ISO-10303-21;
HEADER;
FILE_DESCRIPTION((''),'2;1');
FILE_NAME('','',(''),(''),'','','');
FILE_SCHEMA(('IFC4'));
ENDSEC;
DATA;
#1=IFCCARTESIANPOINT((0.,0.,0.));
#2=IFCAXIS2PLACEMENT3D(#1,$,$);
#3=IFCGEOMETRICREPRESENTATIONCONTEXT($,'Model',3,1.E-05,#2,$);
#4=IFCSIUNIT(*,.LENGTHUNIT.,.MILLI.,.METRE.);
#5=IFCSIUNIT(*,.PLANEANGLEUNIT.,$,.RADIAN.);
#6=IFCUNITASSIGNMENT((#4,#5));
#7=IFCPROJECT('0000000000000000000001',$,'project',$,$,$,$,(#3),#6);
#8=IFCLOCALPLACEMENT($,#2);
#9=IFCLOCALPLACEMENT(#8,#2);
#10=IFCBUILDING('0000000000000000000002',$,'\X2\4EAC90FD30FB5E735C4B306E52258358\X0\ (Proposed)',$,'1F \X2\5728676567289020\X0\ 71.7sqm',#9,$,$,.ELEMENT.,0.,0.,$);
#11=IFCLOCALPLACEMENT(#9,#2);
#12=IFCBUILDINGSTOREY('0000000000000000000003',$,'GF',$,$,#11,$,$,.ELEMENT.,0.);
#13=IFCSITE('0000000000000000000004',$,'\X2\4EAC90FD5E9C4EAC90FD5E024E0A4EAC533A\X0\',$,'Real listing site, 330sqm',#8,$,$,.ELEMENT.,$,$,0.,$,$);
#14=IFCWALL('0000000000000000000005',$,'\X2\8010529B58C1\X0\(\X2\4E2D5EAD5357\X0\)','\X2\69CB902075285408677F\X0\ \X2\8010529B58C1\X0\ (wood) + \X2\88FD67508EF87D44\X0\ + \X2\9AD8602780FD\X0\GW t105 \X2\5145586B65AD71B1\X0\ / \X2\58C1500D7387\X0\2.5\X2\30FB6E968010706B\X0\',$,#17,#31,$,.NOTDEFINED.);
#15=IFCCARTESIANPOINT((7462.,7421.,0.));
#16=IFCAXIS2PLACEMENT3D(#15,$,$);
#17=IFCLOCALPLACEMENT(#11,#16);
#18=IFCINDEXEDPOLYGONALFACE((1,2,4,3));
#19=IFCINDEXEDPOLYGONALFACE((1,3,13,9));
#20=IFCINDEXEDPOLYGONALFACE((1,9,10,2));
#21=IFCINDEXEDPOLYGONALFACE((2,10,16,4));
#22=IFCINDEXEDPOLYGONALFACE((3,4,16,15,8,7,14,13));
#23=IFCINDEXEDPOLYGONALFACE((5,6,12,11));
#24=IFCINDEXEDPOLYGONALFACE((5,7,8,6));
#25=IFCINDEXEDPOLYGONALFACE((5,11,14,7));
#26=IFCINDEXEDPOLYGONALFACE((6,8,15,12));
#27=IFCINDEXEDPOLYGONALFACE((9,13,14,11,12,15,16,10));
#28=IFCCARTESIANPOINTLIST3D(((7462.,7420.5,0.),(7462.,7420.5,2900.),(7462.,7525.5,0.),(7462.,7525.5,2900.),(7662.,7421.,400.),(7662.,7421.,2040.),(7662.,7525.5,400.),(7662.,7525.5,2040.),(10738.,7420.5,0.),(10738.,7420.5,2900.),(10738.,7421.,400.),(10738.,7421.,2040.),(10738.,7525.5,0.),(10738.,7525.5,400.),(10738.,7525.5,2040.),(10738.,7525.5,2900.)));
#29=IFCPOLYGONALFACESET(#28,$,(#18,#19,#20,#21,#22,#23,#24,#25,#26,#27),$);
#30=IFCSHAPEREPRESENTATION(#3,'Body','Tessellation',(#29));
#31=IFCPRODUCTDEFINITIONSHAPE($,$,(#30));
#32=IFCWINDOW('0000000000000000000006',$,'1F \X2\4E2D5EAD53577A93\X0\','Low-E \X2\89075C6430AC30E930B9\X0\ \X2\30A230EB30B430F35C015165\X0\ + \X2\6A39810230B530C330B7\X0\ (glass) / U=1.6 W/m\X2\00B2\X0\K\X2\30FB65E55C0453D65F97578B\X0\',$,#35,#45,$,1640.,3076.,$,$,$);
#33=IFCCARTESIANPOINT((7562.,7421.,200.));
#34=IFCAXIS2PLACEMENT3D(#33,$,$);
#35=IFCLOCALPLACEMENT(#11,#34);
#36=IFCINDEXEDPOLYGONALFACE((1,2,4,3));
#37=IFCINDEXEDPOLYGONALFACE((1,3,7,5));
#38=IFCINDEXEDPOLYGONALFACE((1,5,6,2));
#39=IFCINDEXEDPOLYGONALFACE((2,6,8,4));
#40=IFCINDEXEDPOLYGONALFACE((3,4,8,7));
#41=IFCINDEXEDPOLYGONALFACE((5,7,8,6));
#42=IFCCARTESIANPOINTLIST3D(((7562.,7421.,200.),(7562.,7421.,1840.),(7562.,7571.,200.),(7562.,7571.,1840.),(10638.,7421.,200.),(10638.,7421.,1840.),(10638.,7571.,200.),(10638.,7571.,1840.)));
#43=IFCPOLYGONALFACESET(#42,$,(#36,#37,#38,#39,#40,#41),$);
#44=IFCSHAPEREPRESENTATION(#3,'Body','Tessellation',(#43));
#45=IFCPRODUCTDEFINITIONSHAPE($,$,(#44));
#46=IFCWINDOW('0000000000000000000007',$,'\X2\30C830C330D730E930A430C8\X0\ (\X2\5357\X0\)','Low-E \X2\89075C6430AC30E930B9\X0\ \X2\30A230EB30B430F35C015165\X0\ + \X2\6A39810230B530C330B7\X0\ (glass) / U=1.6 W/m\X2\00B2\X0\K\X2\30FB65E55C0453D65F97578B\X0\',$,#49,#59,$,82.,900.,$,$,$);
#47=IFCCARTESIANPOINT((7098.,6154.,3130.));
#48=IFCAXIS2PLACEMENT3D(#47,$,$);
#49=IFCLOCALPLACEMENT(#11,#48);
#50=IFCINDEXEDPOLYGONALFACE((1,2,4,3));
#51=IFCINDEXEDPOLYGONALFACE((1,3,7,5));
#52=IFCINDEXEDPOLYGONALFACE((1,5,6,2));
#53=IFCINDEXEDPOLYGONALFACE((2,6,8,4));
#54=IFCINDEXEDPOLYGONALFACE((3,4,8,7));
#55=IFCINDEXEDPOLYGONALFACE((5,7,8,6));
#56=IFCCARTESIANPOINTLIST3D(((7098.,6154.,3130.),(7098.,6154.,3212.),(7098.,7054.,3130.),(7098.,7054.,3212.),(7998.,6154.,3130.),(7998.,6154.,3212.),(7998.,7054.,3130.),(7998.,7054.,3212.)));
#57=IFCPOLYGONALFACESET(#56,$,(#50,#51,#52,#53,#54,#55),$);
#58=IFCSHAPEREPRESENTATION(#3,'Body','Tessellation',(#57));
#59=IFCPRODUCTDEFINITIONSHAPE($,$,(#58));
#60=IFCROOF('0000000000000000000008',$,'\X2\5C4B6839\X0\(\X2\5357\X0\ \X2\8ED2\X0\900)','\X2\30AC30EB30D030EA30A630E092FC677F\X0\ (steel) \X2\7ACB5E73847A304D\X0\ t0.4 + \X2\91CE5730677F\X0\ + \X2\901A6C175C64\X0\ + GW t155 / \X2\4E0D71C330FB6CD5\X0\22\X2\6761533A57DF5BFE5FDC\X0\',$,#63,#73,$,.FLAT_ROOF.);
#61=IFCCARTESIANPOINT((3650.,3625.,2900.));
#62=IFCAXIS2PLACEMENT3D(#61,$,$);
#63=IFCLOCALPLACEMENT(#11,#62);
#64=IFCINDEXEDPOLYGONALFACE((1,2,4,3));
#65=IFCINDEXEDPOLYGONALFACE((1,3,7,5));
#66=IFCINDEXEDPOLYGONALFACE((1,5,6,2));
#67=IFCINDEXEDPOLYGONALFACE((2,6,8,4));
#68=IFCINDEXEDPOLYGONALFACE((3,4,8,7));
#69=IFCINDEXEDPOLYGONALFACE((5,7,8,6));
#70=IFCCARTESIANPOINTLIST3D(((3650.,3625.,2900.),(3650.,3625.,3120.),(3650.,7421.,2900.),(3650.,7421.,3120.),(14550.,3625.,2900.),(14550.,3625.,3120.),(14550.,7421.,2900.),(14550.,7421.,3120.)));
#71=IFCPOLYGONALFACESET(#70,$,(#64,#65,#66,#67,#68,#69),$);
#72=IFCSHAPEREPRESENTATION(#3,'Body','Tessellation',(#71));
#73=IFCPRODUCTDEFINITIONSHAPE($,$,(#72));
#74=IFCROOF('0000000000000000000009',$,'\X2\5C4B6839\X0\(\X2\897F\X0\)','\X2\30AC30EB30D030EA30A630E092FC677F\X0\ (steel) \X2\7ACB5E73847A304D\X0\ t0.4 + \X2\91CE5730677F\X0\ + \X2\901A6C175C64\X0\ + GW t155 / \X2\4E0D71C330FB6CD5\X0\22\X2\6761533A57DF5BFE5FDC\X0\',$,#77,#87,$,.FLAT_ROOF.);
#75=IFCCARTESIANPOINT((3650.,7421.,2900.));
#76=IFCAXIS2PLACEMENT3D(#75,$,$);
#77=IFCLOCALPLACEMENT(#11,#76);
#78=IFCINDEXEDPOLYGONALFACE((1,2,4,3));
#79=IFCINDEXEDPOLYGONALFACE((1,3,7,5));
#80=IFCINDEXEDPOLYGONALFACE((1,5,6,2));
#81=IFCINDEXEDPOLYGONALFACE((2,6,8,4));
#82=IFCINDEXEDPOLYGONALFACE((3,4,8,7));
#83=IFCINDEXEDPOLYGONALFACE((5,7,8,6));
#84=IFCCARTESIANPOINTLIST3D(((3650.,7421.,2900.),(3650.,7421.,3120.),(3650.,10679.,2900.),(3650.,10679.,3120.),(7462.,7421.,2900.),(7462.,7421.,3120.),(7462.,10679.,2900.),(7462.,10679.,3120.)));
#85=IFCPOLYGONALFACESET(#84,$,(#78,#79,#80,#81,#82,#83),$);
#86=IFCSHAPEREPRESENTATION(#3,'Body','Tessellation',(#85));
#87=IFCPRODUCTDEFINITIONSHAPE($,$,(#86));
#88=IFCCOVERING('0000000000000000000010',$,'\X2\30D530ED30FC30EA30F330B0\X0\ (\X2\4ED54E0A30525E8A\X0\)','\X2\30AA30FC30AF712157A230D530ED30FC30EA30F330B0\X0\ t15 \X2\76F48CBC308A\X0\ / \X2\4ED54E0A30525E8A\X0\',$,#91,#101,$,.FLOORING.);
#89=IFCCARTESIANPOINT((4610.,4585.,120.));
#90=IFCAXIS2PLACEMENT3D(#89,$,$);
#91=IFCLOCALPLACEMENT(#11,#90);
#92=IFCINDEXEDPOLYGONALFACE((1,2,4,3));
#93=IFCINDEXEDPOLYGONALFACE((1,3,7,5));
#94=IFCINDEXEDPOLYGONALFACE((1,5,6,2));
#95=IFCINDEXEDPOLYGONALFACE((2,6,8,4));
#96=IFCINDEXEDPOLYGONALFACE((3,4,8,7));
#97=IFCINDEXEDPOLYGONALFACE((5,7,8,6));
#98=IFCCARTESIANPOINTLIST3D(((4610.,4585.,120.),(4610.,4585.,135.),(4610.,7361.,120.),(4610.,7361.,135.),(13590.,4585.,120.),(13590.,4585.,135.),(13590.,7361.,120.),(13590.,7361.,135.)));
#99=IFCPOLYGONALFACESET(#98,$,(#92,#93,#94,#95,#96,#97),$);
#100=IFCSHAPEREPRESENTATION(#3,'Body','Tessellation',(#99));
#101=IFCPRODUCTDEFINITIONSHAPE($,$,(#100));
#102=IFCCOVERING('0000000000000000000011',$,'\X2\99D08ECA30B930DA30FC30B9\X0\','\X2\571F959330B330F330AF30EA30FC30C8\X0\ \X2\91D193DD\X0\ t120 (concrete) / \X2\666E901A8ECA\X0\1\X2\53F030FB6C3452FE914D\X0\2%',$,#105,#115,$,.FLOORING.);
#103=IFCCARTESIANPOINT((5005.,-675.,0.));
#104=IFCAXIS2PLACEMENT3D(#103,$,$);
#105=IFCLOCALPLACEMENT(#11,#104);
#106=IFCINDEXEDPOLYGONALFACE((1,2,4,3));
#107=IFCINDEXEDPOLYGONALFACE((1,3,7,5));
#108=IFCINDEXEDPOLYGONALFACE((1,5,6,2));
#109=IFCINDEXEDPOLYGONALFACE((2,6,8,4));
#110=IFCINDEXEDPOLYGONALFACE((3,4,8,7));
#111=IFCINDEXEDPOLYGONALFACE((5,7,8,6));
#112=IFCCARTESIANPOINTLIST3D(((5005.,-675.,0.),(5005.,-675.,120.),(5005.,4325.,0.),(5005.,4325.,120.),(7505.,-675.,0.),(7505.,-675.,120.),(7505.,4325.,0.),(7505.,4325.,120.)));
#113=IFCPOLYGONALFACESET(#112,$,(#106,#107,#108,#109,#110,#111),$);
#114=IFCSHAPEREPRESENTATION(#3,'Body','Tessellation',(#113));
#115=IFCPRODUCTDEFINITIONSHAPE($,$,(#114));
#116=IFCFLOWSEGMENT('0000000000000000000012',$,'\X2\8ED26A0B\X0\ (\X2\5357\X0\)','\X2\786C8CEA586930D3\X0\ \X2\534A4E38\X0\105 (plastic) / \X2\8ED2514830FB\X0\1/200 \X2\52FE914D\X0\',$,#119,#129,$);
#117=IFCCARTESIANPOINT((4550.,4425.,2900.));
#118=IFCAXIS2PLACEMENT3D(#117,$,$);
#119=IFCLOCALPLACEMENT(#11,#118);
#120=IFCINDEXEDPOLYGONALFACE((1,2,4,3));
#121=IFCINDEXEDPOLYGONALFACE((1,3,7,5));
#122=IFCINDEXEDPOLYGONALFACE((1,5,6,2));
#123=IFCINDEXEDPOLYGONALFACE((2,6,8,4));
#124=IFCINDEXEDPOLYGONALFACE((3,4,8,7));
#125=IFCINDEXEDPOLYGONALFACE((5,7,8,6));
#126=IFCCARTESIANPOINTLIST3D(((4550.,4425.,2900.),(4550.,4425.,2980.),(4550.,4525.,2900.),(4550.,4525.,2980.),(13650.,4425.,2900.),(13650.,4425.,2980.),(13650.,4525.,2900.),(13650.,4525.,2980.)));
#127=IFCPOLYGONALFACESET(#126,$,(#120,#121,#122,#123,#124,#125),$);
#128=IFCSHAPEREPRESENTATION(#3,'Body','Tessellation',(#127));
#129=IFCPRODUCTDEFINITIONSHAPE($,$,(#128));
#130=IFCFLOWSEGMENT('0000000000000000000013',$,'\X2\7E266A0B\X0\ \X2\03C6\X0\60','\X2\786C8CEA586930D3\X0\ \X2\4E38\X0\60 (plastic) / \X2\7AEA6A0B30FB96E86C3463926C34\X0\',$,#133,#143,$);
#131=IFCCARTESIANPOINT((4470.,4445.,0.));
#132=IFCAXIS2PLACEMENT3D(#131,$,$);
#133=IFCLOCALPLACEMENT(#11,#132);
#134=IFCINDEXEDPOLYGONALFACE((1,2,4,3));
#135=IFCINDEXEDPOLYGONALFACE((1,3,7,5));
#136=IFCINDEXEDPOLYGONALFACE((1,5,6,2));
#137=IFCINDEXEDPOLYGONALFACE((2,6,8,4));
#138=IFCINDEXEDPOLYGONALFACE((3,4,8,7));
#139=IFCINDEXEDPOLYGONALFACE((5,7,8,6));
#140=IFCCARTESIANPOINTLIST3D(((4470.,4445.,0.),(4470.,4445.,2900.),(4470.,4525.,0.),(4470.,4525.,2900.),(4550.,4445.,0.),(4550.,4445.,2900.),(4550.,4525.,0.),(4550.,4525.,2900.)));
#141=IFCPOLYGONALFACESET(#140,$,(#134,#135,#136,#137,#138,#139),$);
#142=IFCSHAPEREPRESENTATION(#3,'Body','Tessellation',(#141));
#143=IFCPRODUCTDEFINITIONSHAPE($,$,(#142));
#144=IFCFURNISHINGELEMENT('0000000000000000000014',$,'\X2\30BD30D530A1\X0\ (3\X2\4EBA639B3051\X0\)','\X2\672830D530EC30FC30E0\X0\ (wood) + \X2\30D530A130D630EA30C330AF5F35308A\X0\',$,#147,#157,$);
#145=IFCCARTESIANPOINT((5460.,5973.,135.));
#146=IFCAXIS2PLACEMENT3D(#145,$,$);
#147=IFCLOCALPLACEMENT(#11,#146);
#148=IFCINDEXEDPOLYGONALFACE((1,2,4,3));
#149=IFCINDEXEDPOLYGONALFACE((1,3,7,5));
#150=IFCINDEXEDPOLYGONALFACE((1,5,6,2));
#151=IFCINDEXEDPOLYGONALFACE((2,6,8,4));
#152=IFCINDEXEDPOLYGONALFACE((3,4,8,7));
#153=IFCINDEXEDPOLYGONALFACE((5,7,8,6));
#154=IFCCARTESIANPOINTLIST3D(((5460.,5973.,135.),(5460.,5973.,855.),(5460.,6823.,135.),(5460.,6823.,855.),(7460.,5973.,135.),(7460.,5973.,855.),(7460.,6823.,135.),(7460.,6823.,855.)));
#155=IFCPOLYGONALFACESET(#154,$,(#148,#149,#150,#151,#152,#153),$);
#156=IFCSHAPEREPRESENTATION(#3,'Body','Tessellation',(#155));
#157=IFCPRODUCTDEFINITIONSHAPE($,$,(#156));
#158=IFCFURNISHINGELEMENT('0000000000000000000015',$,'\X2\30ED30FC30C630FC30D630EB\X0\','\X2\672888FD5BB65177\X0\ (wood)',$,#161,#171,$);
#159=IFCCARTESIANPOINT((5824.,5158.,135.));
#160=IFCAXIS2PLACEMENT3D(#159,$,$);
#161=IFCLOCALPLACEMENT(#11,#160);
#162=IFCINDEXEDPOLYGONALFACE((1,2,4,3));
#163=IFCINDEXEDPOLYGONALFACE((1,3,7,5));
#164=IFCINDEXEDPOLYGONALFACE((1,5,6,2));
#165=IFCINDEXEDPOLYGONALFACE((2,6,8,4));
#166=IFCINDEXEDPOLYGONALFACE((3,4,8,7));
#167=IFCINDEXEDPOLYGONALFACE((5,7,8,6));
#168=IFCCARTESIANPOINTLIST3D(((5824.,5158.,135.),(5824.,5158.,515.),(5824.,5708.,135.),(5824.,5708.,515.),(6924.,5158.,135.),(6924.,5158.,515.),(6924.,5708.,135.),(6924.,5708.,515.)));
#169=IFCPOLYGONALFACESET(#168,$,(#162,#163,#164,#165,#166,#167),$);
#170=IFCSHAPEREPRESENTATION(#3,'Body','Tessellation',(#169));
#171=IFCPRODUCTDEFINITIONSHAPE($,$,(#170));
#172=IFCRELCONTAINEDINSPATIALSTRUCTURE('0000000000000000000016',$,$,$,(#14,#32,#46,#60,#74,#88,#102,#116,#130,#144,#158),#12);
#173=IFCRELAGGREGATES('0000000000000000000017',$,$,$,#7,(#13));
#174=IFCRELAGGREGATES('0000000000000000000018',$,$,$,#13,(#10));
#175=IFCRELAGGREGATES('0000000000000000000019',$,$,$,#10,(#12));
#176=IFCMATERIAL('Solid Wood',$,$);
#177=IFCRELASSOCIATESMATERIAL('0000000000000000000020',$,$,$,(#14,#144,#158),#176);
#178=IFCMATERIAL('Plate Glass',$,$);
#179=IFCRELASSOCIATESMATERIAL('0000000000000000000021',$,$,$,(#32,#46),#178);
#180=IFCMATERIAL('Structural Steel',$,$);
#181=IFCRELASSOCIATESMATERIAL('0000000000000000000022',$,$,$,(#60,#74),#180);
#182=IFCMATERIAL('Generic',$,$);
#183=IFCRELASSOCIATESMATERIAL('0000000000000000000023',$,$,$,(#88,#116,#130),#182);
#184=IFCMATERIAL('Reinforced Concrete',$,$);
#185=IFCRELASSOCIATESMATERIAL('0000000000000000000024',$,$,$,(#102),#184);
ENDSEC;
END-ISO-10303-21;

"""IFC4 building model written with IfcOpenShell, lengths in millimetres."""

from ifc_helpers import new_model, si_unit, frame, frame_2d, origin, place, context, project, spatial, rectangle, extrude, material, element, fill, save


model = new_model("IFC4")

# Units and contexts
model_context = context("Model", 3, precision=1e-05, world=origin())
ifc_project = project(units=[si_unit("LENGTHUNIT", "METRE", prefix="MILLI"), si_unit("PLANEANGLEUNIT", "RADIAN")], contexts=[model_context])

# Site, building, storey
site_placement = place(None, origin())
site = spatial("IfcSite", under=ifc_project, at=site_placement, Name="京都府京都市上京区", ObjectType="Real listing site, 330sqm", CompositionType="ELEMENT", RefElevation=0.0)
building_placement = place(site_placement, origin())
building = spatial("IfcBuilding", under=site, at=building_placement, Name="京都・平屋の別荘 (Proposed)", ObjectType="1F 在来木造 71.7sqm", CompositionType="ELEMENT", ElevationOfRefHeight=0.0, ElevationOfTerrain=0.0)
storey_placement = place(building_placement, origin())
storey = spatial("IfcBuildingStorey", under=building, at=storey_placement, Name="GF", CompositionType="ELEMENT", Elevation=0.0)

# Shared definitions
ifc_material_1 = material(Name="Solid Wood")

# Shared definitions
ifc_material_2 = material(Name="Reinforced Concrete")

# Shared definitions
ifc_material_3 = material(Name="Plate Glass")

# Wall, opening, window
wall_1_placement = place(storey_placement, frame((7462.0, 7421.0, 0.0)))
wall_1 = element("IfcWall", 1, at=wall_1_placement, inside=storey, material=ifc_material_1, Name="耐力壁(中庭南)", Description="構造用合板 耐力壁 (wood) + 製材軸組 + 高性能GW t105 充填断熱 / 壁倍率2.5・準耐火", PredefinedType="NOTDEFINED", context=model_context, shape_type="SweptSolid", body=[
    extrude(rectangle(XDim=3276.0, YDim=105.0, at=frame_2d((1638.0, 52.0))), frame((7462.0, 7421.0, 0.0)), (0.0, 0.0, 1.0), 2900.0),
])
opening_1_placement = place(storey_placement, frame((7562.0, 7421.0, 200.0)))
opening_1 = element("IfcOpeningElement", 2, at=opening_1_placement, cuts=wall_1, PredefinedType="NOTDEFINED", context=model_context, shape_type="SweptSolid", body=[
    extrude(rectangle(XDim=3076.0, YDim=150.0, at=frame_2d((1538.0, 75.0))), frame((7562.0, 7421.0, 200.0)), (0.0, 0.0, 1.0), 1640.0),
])
window_1_placement = place(storey_placement, frame((7562.0, 7421.0, 200.0)))
window_1 = element("IfcWindow", 3, at=window_1_placement, inside=storey, material=ifc_material_3, Name="1F 中庭南窓", Description="Low-E 複層ガラス アルゴン封入 + 樹脂サッシ (glass) / U=1.6 W/m²K・日射取得型", OverallHeight=1640.0, OverallWidth=3076.0, context=model_context, shape_type="SweptSolid", body=[
    extrude(rectangle(XDim=3076.0, YDim=150.0, at=frame_2d((1538.0, 75.0))), frame((7562.0, 7421.0, 200.0)), (0.0, 0.0, 1.0), 1640.0),
])
fill(opening_1, window_1)

# Window
window_2_placement = place(storey_placement, frame((7098.0, 6154.0, 3130.0)))
element("IfcWindow", 4, at=window_2_placement, inside=storey, material=ifc_material_3, Name="トップライト (南)", Description="Low-E 複層ガラス アルゴン封入 + 樹脂サッシ (glass) / U=1.6 W/m²K・日射取得型", OverallHeight=82.0, OverallWidth=900.0, context=model_context, shape_type="SweptSolid", body=[
    extrude(rectangle(XDim=900.0, YDim=900.0, at=frame_2d((450.0, 450.0))), frame((7098.0, 6154.0, 3130.0)), (0.0, 0.0, 1.0), 82.0),
])

# Roofs
ifc_material_4 = material(Name="Structural Steel")
roof_1_placement = place(storey_placement, frame((3650.0, 3625.0, 2900.0)))
element("IfcRoof", 5, at=roof_1_placement, inside=storey, material=ifc_material_4, Name="屋根(南 軒900)", Description="ガルバリウム鋼板 (steel) 立平葺き t0.4 + 野地板 + 通気層 + GW t155 / 不燃・法22条区域対応", PredefinedType="FLAT_ROOF", context=model_context, shape_type="SweptSolid", body=[
    extrude(rectangle(XDim=10900.0, YDim=3796.0, at=frame_2d((5450.0, 1898.0))), frame((3650.0, 3625.0, 2900.0)), (0.0, 0.0, 1.0), 220.0),
])
roof_2_placement = place(storey_placement, frame((3650.0, 7421.0, 2900.0)))
element("IfcRoof", 6, at=roof_2_placement, inside=storey, material=ifc_material_4, Name="屋根(西)", Description="ガルバリウム鋼板 (steel) 立平葺き t0.4 + 野地板 + 通気層 + GW t155 / 不燃・法22条区域対応", PredefinedType="FLAT_ROOF", context=model_context, shape_type="SweptSolid", body=[
    extrude(rectangle(XDim=3812.0, YDim=3258.0, at=frame_2d((1906.0, 1629.0))), frame((3650.0, 7421.0, 2900.0)), (0.0, 0.0, 1.0), 220.0),
])

# Coverings
ifc_material_5 = material(Name="Generic")
covering_1_placement = place(storey_placement, frame((4610.0, 4585.0, 120.0)))
element("IfcCovering", 7, at=covering_1_placement, inside=storey, material=ifc_material_5, Name="フローリング (仕上げ床)", Description="オーク無垢フローリング t15 直貼り / 仕上げ床", PredefinedType="FLOORING", context=model_context, shape_type="SweptSolid", body=[
    extrude(rectangle(XDim=8980.0, YDim=2776.0, at=frame_2d((4490.0, 1388.0))), frame((4610.0, 4585.0, 120.0)), (0.0, 0.0, 1.0), 15.0),
])
covering_2_placement = place(storey_placement, frame((5005.0, -675.0, 0.0)))
element("IfcCovering", 8, at=covering_2_placement, inside=storey, material=ifc_material_2, Name="駐車スペース", Description="土間コンクリート 金鏝 t120 (concrete) / 普通車1台・水勾配2%", PredefinedType="FLOORING", context=model_context, shape_type="SweptSolid", body=[
    extrude(rectangle(XDim=2500.0, YDim=5000.0, at=frame_2d((1250.0, 2500.0))), frame((5005.0, -675.0, 0.0)), (0.0, 0.0, 1.0), 120.0),
])

# Flow segments
flow_segment_1_placement = place(storey_placement, frame((4550.0, 4425.0, 2900.0)))
element("IfcFlowSegment", 9, at=flow_segment_1_placement, inside=storey, material=ifc_material_5, Name="軒樋 (南)", Description="硬質塩ビ 半丸105 (plastic) / 軒先・1/200 勾配", context=model_context, shape_type="SweptSolid", body=[
    extrude(rectangle(XDim=9100.0, YDim=100.0, at=frame_2d((4550.0, 50.0))), frame((4550.0, 4425.0, 2900.0)), (0.0, 0.0, 1.0), 80.0),
])
flow_segment_2_placement = place(storey_placement, frame((4470.0, 4445.0, 0.0)))
element("IfcFlowSegment", 10, at=flow_segment_2_placement, inside=storey, material=ifc_material_5, Name="縦樋 φ60", Description="硬質塩ビ 丸60 (plastic) / 竪樋・雨水排水", context=model_context, shape_type="SweptSolid", body=[
    extrude(rectangle(XDim=80.0, YDim=80.0, at=frame_2d((40.0, 40.0))), frame((4470.0, 4445.0, 0.0)), (0.0, 0.0, 1.0), 2900.0),
])

# Furnishing elements
furnishing_1_placement = place(storey_placement, frame((5460.0, 5973.0, 135.0)))
element("IfcFurnishingElement", 11, at=furnishing_1_placement, inside=storey, material=ifc_material_1, Name="ソファ (3人掛け)", Description="木フレーム (wood) + ファブリック張り", context=model_context, shape_type="SweptSolid", body=[
    extrude(rectangle(XDim=2000.0, YDim=850.0, at=frame_2d((1000.0, 425.0))), frame((5460.0, 5973.0, 135.0)), (0.0, 0.0, 1.0), 720.0),
])
furnishing_2_placement = place(storey_placement, frame((5824.0, 5158.0, 135.0)))
element("IfcFurnishingElement", 12, at=furnishing_2_placement, inside=storey, material=ifc_material_1, Name="ローテーブル", Description="木製家具 (wood)", context=model_context, shape_type="SweptSolid", body=[
    extrude(rectangle(XDim=1100.0, YDim=550.0, at=frame_2d((550.0, 275.0))), frame((5824.0, 5158.0, 135.0)), (0.0, 0.0, 1.0), 380.0),
])

save(model, "model.ifc")
